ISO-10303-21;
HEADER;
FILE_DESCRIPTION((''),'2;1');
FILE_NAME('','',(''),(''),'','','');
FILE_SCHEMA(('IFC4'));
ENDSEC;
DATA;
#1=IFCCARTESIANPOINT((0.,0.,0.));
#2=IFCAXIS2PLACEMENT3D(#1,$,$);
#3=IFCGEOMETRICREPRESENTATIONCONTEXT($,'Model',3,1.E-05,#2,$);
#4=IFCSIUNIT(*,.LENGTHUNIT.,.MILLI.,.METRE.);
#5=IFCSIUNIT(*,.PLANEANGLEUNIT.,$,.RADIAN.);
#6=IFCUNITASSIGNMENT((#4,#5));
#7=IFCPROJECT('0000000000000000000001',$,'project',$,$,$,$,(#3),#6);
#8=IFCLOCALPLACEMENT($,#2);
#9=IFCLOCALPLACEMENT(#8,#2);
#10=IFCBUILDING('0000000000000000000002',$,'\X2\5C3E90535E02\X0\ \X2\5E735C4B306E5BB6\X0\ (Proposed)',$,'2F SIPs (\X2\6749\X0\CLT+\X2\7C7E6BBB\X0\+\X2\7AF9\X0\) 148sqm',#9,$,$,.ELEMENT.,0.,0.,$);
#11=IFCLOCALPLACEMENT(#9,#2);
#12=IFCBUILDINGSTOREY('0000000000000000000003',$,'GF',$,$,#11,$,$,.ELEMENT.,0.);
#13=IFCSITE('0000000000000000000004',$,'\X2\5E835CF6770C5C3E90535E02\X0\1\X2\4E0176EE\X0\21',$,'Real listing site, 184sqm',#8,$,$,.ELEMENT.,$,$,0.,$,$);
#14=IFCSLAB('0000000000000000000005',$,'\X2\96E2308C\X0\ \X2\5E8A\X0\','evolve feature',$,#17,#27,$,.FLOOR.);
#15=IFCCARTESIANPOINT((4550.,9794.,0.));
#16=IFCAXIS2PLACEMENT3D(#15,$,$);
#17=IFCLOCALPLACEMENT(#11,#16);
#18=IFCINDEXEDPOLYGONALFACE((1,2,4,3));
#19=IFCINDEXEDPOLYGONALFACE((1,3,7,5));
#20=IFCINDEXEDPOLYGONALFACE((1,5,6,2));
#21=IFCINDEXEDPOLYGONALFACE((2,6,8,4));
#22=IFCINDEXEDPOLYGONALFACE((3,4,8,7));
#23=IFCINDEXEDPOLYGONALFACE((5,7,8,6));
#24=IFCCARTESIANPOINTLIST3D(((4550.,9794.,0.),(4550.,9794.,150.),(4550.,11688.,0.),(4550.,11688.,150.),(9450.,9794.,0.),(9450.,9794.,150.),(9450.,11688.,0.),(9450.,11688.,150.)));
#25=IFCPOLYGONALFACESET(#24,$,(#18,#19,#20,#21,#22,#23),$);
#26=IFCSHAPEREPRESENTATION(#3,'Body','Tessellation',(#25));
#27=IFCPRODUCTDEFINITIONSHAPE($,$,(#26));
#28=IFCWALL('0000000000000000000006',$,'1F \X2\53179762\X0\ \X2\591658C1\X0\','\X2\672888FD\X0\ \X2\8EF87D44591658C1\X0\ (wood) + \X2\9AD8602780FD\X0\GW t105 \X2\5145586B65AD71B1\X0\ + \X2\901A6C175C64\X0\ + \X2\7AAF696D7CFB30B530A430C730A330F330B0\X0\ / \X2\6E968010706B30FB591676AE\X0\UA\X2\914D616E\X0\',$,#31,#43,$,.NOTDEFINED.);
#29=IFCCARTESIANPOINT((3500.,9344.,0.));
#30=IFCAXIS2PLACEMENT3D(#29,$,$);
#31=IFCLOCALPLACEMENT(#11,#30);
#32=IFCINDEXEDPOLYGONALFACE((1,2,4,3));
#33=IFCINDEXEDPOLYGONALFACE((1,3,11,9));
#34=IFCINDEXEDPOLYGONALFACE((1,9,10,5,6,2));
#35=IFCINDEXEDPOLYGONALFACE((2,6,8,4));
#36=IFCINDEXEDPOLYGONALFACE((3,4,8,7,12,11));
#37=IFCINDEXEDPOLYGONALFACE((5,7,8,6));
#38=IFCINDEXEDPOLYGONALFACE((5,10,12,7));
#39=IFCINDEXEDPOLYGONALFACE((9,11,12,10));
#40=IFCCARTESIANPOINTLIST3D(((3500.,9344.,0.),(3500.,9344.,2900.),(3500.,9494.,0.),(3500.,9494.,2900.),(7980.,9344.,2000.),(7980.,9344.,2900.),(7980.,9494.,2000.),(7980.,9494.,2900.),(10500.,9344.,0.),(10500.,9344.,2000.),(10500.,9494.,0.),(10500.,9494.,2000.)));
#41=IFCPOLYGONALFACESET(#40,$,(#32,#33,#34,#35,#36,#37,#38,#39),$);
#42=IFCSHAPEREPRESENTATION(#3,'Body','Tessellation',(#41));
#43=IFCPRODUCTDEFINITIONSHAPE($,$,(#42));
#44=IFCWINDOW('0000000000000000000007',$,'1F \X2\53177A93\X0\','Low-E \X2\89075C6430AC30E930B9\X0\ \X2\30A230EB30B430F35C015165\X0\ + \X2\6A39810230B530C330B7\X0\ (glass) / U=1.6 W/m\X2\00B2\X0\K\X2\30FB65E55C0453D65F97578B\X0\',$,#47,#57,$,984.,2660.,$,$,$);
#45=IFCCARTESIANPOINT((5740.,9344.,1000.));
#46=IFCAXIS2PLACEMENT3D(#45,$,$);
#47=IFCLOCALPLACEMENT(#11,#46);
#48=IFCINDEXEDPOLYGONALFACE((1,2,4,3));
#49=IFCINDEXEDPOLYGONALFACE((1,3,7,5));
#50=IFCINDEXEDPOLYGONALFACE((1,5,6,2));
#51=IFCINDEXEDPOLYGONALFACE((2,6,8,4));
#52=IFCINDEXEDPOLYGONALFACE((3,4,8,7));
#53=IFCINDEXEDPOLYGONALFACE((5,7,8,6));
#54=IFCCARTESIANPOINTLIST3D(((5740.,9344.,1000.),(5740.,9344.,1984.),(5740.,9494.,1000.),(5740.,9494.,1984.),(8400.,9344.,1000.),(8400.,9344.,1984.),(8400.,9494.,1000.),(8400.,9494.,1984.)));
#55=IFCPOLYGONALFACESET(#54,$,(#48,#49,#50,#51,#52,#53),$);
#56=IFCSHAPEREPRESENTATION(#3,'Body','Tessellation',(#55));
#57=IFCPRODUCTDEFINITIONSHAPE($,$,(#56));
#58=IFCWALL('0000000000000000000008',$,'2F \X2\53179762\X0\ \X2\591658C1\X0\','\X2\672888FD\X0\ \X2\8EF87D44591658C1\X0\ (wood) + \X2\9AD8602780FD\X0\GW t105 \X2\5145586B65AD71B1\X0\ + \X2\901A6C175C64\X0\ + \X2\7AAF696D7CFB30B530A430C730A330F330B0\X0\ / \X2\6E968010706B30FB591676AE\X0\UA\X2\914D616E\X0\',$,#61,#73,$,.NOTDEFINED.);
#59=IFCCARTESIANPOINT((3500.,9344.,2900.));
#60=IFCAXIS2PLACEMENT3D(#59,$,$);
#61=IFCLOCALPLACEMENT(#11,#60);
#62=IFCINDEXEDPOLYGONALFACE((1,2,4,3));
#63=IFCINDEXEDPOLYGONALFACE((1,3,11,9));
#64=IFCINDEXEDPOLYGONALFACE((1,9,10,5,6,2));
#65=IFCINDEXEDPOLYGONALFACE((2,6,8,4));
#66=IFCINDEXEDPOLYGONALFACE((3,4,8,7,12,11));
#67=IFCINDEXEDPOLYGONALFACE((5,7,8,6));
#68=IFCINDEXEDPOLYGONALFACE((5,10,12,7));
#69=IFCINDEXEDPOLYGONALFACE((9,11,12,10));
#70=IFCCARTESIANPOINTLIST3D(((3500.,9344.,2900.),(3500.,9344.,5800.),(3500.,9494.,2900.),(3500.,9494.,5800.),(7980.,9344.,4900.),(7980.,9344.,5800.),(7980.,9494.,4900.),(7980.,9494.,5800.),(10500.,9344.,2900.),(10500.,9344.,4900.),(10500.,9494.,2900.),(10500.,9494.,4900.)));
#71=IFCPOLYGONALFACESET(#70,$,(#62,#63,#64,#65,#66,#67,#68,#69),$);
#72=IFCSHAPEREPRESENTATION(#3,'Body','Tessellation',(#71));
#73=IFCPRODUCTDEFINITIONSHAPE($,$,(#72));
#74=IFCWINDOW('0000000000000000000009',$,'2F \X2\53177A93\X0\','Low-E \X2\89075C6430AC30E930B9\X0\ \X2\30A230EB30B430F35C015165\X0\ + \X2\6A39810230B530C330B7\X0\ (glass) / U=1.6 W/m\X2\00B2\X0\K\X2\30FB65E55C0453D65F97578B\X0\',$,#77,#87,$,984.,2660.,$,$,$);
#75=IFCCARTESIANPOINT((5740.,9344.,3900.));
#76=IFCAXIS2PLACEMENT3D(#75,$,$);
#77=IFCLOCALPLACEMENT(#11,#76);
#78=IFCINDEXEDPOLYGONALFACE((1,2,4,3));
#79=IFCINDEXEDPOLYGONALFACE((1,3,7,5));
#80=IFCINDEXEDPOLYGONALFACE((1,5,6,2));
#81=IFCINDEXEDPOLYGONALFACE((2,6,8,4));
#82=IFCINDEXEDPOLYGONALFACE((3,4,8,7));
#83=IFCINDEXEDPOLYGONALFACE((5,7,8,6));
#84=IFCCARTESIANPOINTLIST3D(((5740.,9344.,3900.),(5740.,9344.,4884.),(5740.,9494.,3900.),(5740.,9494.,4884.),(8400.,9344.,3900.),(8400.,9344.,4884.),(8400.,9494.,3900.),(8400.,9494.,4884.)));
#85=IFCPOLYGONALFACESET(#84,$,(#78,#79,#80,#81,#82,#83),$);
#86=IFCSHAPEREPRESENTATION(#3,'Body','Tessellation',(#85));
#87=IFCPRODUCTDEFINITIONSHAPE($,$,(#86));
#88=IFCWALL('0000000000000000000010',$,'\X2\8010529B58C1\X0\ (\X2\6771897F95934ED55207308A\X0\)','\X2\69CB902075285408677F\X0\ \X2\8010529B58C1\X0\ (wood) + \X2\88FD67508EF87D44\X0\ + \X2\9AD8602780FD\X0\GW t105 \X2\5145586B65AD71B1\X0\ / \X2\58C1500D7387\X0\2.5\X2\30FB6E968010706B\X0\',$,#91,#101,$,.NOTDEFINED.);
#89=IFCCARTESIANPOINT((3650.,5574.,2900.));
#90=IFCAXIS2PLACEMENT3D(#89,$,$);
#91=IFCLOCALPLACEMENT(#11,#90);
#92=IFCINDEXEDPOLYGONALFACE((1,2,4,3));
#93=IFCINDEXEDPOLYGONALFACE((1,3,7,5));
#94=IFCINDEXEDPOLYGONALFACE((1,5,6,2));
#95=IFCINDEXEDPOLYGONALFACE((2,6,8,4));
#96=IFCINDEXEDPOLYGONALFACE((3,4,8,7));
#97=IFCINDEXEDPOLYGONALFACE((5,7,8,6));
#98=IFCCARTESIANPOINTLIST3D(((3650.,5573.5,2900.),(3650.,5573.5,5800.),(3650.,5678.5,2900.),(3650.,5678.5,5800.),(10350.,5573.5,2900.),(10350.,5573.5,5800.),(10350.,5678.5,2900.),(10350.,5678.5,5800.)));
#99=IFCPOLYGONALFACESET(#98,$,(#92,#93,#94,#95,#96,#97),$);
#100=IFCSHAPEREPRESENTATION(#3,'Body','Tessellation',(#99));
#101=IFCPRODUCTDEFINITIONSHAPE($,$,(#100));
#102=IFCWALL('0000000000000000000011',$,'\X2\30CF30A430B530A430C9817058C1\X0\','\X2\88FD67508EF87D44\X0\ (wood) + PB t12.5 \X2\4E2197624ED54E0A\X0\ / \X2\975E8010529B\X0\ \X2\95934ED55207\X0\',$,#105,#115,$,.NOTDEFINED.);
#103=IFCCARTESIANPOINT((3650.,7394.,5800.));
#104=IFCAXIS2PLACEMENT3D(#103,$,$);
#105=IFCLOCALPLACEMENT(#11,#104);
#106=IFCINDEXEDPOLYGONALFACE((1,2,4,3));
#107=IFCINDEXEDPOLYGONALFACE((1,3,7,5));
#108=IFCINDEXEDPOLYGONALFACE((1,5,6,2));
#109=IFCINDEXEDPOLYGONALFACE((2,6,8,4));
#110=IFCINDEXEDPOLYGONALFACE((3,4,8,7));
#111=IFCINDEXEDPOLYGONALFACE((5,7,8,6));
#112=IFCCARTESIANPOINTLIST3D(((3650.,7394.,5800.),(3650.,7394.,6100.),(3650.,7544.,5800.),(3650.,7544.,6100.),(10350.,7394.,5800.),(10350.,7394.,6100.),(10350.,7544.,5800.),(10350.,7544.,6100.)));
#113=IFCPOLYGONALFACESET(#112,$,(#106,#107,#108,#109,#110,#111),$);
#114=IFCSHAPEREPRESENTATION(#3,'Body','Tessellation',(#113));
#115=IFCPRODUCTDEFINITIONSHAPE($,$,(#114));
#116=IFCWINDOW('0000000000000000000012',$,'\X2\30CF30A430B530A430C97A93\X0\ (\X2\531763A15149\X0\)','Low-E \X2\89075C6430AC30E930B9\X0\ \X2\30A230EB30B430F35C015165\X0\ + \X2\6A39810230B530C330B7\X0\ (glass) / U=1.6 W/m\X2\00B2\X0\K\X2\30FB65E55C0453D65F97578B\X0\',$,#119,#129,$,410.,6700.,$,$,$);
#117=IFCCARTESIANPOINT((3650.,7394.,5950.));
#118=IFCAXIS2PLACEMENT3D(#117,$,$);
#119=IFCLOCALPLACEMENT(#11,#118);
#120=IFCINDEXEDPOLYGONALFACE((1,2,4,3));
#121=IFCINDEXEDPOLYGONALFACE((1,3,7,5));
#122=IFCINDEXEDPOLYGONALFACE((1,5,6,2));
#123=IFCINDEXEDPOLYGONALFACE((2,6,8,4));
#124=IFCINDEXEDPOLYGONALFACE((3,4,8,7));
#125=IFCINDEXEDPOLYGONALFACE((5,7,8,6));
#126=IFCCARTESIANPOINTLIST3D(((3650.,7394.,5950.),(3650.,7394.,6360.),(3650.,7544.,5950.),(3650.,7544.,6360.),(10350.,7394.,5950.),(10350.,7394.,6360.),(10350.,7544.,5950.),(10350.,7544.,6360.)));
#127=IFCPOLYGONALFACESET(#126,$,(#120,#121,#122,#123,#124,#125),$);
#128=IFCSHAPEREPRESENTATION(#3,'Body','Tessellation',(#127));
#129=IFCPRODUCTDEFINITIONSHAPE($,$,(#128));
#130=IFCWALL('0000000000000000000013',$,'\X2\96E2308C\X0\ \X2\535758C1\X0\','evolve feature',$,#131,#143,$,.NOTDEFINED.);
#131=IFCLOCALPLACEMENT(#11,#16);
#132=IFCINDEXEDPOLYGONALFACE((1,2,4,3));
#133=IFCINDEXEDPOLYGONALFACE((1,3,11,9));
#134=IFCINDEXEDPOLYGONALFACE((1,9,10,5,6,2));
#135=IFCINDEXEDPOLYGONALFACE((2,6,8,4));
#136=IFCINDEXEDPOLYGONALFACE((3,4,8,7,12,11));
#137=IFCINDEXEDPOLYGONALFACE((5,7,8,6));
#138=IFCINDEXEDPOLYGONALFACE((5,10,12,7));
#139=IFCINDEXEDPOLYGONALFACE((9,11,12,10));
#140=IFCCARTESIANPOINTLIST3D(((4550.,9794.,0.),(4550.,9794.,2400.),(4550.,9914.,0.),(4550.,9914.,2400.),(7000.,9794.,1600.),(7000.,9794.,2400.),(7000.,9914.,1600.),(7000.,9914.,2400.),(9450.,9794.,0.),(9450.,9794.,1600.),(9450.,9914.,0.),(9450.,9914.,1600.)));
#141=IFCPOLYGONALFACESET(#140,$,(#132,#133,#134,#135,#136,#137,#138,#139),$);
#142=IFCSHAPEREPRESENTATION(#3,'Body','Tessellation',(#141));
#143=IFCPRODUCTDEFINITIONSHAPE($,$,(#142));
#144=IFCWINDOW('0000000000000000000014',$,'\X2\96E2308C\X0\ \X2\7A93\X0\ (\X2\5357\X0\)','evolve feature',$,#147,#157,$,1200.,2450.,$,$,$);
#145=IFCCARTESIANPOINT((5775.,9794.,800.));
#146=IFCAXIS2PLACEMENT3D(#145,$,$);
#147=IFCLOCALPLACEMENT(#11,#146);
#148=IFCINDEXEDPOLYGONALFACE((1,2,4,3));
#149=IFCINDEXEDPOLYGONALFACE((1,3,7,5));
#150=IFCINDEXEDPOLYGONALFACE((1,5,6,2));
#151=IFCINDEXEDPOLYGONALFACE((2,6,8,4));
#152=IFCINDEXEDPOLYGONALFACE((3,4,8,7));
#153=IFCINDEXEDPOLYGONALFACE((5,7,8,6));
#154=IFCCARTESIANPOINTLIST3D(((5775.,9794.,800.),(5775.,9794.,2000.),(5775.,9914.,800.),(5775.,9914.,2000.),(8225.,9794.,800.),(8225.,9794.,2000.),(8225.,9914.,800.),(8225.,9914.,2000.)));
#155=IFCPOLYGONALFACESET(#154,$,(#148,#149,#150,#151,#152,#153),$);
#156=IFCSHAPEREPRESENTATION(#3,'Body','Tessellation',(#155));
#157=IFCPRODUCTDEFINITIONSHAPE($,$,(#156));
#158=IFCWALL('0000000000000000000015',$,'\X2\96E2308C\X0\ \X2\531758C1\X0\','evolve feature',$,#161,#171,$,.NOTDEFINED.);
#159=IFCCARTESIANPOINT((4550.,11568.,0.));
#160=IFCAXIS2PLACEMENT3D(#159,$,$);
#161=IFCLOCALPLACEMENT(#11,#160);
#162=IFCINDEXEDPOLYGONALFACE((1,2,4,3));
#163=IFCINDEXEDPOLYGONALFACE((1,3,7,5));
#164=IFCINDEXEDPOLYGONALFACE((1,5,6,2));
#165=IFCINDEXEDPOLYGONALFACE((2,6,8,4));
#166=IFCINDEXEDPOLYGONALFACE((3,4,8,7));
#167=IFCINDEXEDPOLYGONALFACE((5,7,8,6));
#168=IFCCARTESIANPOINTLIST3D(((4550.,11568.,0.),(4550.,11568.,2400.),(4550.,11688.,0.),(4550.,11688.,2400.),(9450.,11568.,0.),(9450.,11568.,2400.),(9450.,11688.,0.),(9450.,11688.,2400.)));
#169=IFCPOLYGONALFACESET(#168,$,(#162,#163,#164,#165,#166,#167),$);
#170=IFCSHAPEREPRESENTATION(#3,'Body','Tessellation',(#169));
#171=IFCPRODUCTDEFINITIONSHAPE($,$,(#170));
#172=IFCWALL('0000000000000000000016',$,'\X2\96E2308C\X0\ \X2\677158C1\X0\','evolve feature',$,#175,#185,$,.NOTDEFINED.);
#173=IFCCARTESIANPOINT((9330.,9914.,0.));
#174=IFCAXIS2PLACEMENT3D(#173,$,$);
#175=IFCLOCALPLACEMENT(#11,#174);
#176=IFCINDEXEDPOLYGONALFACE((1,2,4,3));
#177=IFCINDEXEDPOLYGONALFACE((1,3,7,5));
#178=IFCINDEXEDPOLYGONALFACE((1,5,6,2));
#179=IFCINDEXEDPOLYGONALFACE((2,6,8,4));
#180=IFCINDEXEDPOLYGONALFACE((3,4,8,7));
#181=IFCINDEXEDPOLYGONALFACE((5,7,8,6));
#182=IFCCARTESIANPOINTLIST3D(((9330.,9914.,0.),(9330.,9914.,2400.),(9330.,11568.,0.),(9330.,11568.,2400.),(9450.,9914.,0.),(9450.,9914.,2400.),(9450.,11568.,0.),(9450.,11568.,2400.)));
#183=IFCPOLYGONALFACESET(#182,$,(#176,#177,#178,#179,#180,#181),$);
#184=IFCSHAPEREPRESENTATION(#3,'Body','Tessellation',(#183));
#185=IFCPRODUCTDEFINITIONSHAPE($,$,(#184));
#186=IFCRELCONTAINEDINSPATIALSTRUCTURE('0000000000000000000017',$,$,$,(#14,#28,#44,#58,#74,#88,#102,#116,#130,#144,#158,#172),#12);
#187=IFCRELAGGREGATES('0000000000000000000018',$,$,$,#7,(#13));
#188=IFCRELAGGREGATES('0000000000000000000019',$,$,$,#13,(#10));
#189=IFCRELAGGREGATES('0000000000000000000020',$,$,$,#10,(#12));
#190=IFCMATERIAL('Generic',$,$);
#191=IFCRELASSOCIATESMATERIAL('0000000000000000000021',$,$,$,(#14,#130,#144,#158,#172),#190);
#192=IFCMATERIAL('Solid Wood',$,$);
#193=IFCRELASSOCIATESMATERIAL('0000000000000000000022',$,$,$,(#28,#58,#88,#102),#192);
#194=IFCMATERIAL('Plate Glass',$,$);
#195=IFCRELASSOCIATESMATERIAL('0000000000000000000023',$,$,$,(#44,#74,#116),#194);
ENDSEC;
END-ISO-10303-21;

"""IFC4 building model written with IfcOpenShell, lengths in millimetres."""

from ifc_helpers import new_model, si_unit, frame, frame_2d, origin, place, context, project, spatial, rectangle, extrude, material, element, fill, save


model = new_model("IFC4")

# Units and contexts
model_context = context("Model", 3, precision=1e-05, world=origin())
ifc_project = project(units=[si_unit("LENGTHUNIT", "METRE", prefix="MILLI"), si_unit("PLANEANGLEUNIT", "RADIAN")], contexts=[model_context])

# Site, building, storey
site_placement = place(None, origin())
site = spatial("IfcSite", under=ifc_project, at=site_placement, Name="広島県尾道市1丁目21", ObjectType="Real listing site, 184sqm", CompositionType="ELEMENT", RefElevation=0.0)
building_placement = place(site_placement, origin())
building = spatial("IfcBuilding", under=site, at=building_placement, Name="尾道市 平屋の家 (Proposed)", ObjectType="2F SIPs (杉CLT+籾殻+竹) 148sqm", CompositionType="ELEMENT", ElevationOfRefHeight=0.0, ElevationOfTerrain=0.0)
storey_placement = place(building_placement, origin())
storey = spatial("IfcBuildingStorey", under=building, at=storey_placement, Name="GF", CompositionType="ELEMENT", Elevation=0.0)

# Slab
ifc_material_1 = material(Name="Generic")
slab_placement = place(storey_placement, frame((4550.0, 9794.0, 0.0)))
element("IfcSlab", 1, at=slab_placement, inside=storey, material=ifc_material_1, Name="離れ 床", Description="evolve feature", PredefinedType="FLOOR", context=model_context, shape_type="SweptSolid", body=[
    extrude(rectangle(XDim=4900.0, YDim=1894.0, at=frame_2d((2450.0, 947.0))), frame((4550.0, 9794.0, 0.0)), (0.0, 0.0, 1.0), 150.0),
])

# Wall, opening, window
ifc_material_2 = material(Name="Solid Wood")
wall_1_placement = place(storey_placement, frame((3500.0, 9344.0, 0.0)))
wall_1 = element("IfcWall", 2, at=wall_1_placement, inside=storey, material=ifc_material_2, Name="1F 北面 外壁", Description="木製 軸組外壁 (wood) + 高性能GW t105 充填断熱 + 通気層 + 窯業系サイディング / 準耐火・外皮UA配慮", PredefinedType="NOTDEFINED", context=model_context, shape_type="SweptSolid", body=[
    extrude(rectangle(XDim=7000.0, YDim=150.0, at=frame_2d((3500.0, 75.0))), frame((3500.0, 9344.0, 0.0)), (0.0, 0.0, 1.0), 2900.0),
])
opening_1_placement = place(storey_placement, frame((5740.0, 9344.0, 1000.0)))
opening_1 = element("IfcOpeningElement", 3, at=opening_1_placement, cuts=wall_1, PredefinedType="NOTDEFINED", context=model_context, shape_type="SweptSolid", body=[
    extrude(rectangle(XDim=2660.0, YDim=150.0, at=frame_2d((1330.0, 75.0))), frame((5740.0, 9344.0, 1000.0)), (0.0, 0.0, 1.0), 984.0),
])
ifc_material_3 = material(Name="Plate Glass")
window_1_placement = place(storey_placement, frame((5740.0, 9344.0, 1000.0)))
window_1 = element("IfcWindow", 4, at=window_1_placement, inside=storey, material=ifc_material_3, Name="1F 北窓", Description="Low-E 複層ガラス アルゴン封入 + 樹脂サッシ (glass) / U=1.6 W/m²K・日射取得型", OverallHeight=984.0, OverallWidth=2660.0, context=model_context, shape_type="SweptSolid", body=[
    extrude(rectangle(XDim=2660.0, YDim=150.0, at=frame_2d((1330.0, 75.0))), frame((5740.0, 9344.0, 1000.0)), (0.0, 0.0, 1.0), 984.0),
])
fill(opening_1, window_1)

# Wall, opening, window
wall_2_placement = place(storey_placement, frame((3500.0, 9344.0, 2900.0)))
wall_2 = element("IfcWall", 5, at=wall_2_placement, inside=storey, material=ifc_material_2, Name="2F 北面 外壁", Description="木製 軸組外壁 (wood) + 高性能GW t105 充填断熱 + 通気層 + 窯業系サイディング / 準耐火・外皮UA配慮", PredefinedType="NOTDEFINED", context=model_context, shape_type="SweptSolid", body=[
    extrude(rectangle(XDim=7000.0, YDim=150.0, at=frame_2d((3500.0, 75.0))), frame((3500.0, 9344.0, 2900.0)), (0.0, 0.0, 1.0), 2900.0),
])
opening_2_placement = place(storey_placement, frame((5740.0, 9344.0, 3900.0)))
opening_2 = element("IfcOpeningElement", 6, at=opening_2_placement, cuts=wall_2, PredefinedType="NOTDEFINED", context=model_context, shape_type="SweptSolid", body=[
    extrude(rectangle(XDim=2660.0, YDim=150.0, at=frame_2d((1330.0, 75.0))), frame((5740.0, 9344.0, 3900.0)), (0.0, 0.0, 1.0), 984.0),
])
window_2_placement = place(storey_placement, frame((5740.0, 9344.0, 3900.0)))
window_2 = element("IfcWindow", 7, at=window_2_placement, inside=storey, material=ifc_material_3, Name="2F 北窓", Description="Low-E 複層ガラス アルゴン封入 + 樹脂サッシ (glass) / U=1.6 W/m²K・日射取得型", OverallHeight=984.0, OverallWidth=2660.0, context=model_context, shape_type="SweptSolid", body=[
    extrude(rectangle(XDim=2660.0, YDim=150.0, at=frame_2d((1330.0, 75.0))), frame((5740.0, 9344.0, 3900.0)), (0.0, 0.0, 1.0), 984.0),
])
fill(opening_2, window_2)

# Wall
wall_3_placement = place(storey_placement, frame((3650.0, 5574.0, 2900.0)))
element("IfcWall", 8, at=wall_3_placement, inside=storey, material=ifc_material_2, Name="耐力壁 (東西間仕切り)", Description="構造用合板 耐力壁 (wood) + 製材軸組 + 高性能GW t105 充填断熱 / 壁倍率2.5・準耐火", PredefinedType="NOTDEFINED", context=model_context, shape_type="SweptSolid", body=[
    extrude(rectangle(XDim=6700.0, YDim=105.0, at=frame_2d((3350.0, 52.0))), frame((3650.0, 5574.0, 2900.0)), (0.0, 0.0, 1.0), 2900.0),
])

# Walls, openings, windows
wall_4_placement = place(storey_placement, frame((3650.0, 7394.0, 5800.0)))
wall_4 = element("IfcWall", 9, at=wall_4_placement, inside=storey, material=ifc_material_2, Name="ハイサイド腰壁", Description="製材軸組 (wood) + PB t12.5 両面仕上 / 非耐力 間仕切", PredefinedType="NOTDEFINED", context=model_context, shape_type="SweptSolid", body=[
    extrude(rectangle(XDim=6700.0, YDim=150.0, at=frame_2d((3350.0, 75.0))), frame((3650.0, 7394.0, 5800.0)), (0.0, 0.0, 1.0), 700.0),
])
opening_3_placement = place(storey_placement, frame((3650.0, 7394.0, 5950.0)))
opening_3 = element("IfcOpeningElement", 10, at=opening_3_placement, cuts=wall_4, PredefinedType="NOTDEFINED", context=model_context, shape_type="SweptSolid", body=[
    extrude(rectangle(XDim=6700.0, YDim=150.0, at=frame_2d((3350.0, 75.0))), frame((3650.0, 7394.0, 5950.0)), (0.0, 0.0, 1.0), 410.0),
])
window_3_placement = place(storey_placement, frame((3650.0, 7394.0, 5950.0)))
window_3 = element("IfcWindow", 11, at=window_3_placement, inside=storey, material=ifc_material_3, Name="ハイサイド窓 (北採光)", Description="Low-E 複層ガラス アルゴン封入 + 樹脂サッシ (glass) / U=1.6 W/m²K・日射取得型", OverallHeight=410.0, OverallWidth=6700.0, context=model_context, shape_type="SweptSolid", body=[
    extrude(rectangle(XDim=6700.0, YDim=150.0, at=frame_2d((3350.0, 75.0))), frame((3650.0, 7394.0, 5950.0)), (0.0, 0.0, 1.0), 410.0),
])
fill(opening_3, window_3)
wall_5_placement = place(storey_placement, frame((4550.0, 9794.0, 0.0)))
wall_5 = element("IfcWall", 12, at=wall_5_placement, inside=storey, material=ifc_material_1, Name="離れ 南壁", Description="evolve feature", PredefinedType="NOTDEFINED", context=model_context, shape_type="SweptSolid", body=[
    extrude(rectangle(XDim=4900.0, YDim=120.0, at=frame_2d((2450.0, 60.0))), frame((4550.0, 9794.0, 0.0)), (0.0, 0.0, 1.0), 2400.0),
])
opening_4_placement = place(storey_placement, frame((5775.0, 9794.0, 800.0)))
opening_4 = element("IfcOpeningElement", 13, at=opening_4_placement, cuts=wall_5, PredefinedType="NOTDEFINED", context=model_context, shape_type="SweptSolid", body=[
    extrude(rectangle(XDim=2450.0, YDim=120.0, at=frame_2d((1225.0, 60.0))), frame((5775.0, 9794.0, 800.0)), (0.0, 0.0, 1.0), 1200.0),
])
window_4_placement = place(storey_placement, frame((5775.0, 9794.0, 800.0)))
window_4 = element("IfcWindow", 14, at=window_4_placement, inside=storey, material=ifc_material_1, Name="離れ 窓 (南)", Description="evolve feature", OverallHeight=1200.0, OverallWidth=2450.0, context=model_context, shape_type="SweptSolid", body=[
    extrude(rectangle(XDim=2450.0, YDim=120.0, at=frame_2d((1225.0, 60.0))), frame((5775.0, 9794.0, 800.0)), (0.0, 0.0, 1.0), 1200.0),
])
fill(opening_4, window_4)

# Walls
wall_6_placement = place(storey_placement, frame((4550.0, 11568.0, 0.0)))
element("IfcWall", 15, at=wall_6_placement, inside=storey, material=ifc_material_1, Name="離れ 北壁", Description="evolve feature", PredefinedType="NOTDEFINED", context=model_context, shape_type="SweptSolid", body=[
    extrude(rectangle(XDim=4900.0, YDim=120.0, at=frame_2d((2450.0, 60.0))), frame((4550.0, 11568.0, 0.0)), (0.0, 0.0, 1.0), 2400.0),
])
wall_7_placement = place(storey_placement, frame((9330.0, 9914.0, 0.0)))
element("IfcWall", 16, at=wall_7_placement, inside=storey, material=ifc_material_1, Name="離れ 東壁", Description="evolve feature", PredefinedType="NOTDEFINED", context=model_context, shape_type="SweptSolid", body=[
    extrude(rectangle(XDim=120.0, YDim=1654.0, at=frame_2d((60.0, 827.0))), frame((9330.0, 9914.0, 0.0)), (0.0, 0.0, 1.0), 2400.0),
])

save(model, "model.ifc")
